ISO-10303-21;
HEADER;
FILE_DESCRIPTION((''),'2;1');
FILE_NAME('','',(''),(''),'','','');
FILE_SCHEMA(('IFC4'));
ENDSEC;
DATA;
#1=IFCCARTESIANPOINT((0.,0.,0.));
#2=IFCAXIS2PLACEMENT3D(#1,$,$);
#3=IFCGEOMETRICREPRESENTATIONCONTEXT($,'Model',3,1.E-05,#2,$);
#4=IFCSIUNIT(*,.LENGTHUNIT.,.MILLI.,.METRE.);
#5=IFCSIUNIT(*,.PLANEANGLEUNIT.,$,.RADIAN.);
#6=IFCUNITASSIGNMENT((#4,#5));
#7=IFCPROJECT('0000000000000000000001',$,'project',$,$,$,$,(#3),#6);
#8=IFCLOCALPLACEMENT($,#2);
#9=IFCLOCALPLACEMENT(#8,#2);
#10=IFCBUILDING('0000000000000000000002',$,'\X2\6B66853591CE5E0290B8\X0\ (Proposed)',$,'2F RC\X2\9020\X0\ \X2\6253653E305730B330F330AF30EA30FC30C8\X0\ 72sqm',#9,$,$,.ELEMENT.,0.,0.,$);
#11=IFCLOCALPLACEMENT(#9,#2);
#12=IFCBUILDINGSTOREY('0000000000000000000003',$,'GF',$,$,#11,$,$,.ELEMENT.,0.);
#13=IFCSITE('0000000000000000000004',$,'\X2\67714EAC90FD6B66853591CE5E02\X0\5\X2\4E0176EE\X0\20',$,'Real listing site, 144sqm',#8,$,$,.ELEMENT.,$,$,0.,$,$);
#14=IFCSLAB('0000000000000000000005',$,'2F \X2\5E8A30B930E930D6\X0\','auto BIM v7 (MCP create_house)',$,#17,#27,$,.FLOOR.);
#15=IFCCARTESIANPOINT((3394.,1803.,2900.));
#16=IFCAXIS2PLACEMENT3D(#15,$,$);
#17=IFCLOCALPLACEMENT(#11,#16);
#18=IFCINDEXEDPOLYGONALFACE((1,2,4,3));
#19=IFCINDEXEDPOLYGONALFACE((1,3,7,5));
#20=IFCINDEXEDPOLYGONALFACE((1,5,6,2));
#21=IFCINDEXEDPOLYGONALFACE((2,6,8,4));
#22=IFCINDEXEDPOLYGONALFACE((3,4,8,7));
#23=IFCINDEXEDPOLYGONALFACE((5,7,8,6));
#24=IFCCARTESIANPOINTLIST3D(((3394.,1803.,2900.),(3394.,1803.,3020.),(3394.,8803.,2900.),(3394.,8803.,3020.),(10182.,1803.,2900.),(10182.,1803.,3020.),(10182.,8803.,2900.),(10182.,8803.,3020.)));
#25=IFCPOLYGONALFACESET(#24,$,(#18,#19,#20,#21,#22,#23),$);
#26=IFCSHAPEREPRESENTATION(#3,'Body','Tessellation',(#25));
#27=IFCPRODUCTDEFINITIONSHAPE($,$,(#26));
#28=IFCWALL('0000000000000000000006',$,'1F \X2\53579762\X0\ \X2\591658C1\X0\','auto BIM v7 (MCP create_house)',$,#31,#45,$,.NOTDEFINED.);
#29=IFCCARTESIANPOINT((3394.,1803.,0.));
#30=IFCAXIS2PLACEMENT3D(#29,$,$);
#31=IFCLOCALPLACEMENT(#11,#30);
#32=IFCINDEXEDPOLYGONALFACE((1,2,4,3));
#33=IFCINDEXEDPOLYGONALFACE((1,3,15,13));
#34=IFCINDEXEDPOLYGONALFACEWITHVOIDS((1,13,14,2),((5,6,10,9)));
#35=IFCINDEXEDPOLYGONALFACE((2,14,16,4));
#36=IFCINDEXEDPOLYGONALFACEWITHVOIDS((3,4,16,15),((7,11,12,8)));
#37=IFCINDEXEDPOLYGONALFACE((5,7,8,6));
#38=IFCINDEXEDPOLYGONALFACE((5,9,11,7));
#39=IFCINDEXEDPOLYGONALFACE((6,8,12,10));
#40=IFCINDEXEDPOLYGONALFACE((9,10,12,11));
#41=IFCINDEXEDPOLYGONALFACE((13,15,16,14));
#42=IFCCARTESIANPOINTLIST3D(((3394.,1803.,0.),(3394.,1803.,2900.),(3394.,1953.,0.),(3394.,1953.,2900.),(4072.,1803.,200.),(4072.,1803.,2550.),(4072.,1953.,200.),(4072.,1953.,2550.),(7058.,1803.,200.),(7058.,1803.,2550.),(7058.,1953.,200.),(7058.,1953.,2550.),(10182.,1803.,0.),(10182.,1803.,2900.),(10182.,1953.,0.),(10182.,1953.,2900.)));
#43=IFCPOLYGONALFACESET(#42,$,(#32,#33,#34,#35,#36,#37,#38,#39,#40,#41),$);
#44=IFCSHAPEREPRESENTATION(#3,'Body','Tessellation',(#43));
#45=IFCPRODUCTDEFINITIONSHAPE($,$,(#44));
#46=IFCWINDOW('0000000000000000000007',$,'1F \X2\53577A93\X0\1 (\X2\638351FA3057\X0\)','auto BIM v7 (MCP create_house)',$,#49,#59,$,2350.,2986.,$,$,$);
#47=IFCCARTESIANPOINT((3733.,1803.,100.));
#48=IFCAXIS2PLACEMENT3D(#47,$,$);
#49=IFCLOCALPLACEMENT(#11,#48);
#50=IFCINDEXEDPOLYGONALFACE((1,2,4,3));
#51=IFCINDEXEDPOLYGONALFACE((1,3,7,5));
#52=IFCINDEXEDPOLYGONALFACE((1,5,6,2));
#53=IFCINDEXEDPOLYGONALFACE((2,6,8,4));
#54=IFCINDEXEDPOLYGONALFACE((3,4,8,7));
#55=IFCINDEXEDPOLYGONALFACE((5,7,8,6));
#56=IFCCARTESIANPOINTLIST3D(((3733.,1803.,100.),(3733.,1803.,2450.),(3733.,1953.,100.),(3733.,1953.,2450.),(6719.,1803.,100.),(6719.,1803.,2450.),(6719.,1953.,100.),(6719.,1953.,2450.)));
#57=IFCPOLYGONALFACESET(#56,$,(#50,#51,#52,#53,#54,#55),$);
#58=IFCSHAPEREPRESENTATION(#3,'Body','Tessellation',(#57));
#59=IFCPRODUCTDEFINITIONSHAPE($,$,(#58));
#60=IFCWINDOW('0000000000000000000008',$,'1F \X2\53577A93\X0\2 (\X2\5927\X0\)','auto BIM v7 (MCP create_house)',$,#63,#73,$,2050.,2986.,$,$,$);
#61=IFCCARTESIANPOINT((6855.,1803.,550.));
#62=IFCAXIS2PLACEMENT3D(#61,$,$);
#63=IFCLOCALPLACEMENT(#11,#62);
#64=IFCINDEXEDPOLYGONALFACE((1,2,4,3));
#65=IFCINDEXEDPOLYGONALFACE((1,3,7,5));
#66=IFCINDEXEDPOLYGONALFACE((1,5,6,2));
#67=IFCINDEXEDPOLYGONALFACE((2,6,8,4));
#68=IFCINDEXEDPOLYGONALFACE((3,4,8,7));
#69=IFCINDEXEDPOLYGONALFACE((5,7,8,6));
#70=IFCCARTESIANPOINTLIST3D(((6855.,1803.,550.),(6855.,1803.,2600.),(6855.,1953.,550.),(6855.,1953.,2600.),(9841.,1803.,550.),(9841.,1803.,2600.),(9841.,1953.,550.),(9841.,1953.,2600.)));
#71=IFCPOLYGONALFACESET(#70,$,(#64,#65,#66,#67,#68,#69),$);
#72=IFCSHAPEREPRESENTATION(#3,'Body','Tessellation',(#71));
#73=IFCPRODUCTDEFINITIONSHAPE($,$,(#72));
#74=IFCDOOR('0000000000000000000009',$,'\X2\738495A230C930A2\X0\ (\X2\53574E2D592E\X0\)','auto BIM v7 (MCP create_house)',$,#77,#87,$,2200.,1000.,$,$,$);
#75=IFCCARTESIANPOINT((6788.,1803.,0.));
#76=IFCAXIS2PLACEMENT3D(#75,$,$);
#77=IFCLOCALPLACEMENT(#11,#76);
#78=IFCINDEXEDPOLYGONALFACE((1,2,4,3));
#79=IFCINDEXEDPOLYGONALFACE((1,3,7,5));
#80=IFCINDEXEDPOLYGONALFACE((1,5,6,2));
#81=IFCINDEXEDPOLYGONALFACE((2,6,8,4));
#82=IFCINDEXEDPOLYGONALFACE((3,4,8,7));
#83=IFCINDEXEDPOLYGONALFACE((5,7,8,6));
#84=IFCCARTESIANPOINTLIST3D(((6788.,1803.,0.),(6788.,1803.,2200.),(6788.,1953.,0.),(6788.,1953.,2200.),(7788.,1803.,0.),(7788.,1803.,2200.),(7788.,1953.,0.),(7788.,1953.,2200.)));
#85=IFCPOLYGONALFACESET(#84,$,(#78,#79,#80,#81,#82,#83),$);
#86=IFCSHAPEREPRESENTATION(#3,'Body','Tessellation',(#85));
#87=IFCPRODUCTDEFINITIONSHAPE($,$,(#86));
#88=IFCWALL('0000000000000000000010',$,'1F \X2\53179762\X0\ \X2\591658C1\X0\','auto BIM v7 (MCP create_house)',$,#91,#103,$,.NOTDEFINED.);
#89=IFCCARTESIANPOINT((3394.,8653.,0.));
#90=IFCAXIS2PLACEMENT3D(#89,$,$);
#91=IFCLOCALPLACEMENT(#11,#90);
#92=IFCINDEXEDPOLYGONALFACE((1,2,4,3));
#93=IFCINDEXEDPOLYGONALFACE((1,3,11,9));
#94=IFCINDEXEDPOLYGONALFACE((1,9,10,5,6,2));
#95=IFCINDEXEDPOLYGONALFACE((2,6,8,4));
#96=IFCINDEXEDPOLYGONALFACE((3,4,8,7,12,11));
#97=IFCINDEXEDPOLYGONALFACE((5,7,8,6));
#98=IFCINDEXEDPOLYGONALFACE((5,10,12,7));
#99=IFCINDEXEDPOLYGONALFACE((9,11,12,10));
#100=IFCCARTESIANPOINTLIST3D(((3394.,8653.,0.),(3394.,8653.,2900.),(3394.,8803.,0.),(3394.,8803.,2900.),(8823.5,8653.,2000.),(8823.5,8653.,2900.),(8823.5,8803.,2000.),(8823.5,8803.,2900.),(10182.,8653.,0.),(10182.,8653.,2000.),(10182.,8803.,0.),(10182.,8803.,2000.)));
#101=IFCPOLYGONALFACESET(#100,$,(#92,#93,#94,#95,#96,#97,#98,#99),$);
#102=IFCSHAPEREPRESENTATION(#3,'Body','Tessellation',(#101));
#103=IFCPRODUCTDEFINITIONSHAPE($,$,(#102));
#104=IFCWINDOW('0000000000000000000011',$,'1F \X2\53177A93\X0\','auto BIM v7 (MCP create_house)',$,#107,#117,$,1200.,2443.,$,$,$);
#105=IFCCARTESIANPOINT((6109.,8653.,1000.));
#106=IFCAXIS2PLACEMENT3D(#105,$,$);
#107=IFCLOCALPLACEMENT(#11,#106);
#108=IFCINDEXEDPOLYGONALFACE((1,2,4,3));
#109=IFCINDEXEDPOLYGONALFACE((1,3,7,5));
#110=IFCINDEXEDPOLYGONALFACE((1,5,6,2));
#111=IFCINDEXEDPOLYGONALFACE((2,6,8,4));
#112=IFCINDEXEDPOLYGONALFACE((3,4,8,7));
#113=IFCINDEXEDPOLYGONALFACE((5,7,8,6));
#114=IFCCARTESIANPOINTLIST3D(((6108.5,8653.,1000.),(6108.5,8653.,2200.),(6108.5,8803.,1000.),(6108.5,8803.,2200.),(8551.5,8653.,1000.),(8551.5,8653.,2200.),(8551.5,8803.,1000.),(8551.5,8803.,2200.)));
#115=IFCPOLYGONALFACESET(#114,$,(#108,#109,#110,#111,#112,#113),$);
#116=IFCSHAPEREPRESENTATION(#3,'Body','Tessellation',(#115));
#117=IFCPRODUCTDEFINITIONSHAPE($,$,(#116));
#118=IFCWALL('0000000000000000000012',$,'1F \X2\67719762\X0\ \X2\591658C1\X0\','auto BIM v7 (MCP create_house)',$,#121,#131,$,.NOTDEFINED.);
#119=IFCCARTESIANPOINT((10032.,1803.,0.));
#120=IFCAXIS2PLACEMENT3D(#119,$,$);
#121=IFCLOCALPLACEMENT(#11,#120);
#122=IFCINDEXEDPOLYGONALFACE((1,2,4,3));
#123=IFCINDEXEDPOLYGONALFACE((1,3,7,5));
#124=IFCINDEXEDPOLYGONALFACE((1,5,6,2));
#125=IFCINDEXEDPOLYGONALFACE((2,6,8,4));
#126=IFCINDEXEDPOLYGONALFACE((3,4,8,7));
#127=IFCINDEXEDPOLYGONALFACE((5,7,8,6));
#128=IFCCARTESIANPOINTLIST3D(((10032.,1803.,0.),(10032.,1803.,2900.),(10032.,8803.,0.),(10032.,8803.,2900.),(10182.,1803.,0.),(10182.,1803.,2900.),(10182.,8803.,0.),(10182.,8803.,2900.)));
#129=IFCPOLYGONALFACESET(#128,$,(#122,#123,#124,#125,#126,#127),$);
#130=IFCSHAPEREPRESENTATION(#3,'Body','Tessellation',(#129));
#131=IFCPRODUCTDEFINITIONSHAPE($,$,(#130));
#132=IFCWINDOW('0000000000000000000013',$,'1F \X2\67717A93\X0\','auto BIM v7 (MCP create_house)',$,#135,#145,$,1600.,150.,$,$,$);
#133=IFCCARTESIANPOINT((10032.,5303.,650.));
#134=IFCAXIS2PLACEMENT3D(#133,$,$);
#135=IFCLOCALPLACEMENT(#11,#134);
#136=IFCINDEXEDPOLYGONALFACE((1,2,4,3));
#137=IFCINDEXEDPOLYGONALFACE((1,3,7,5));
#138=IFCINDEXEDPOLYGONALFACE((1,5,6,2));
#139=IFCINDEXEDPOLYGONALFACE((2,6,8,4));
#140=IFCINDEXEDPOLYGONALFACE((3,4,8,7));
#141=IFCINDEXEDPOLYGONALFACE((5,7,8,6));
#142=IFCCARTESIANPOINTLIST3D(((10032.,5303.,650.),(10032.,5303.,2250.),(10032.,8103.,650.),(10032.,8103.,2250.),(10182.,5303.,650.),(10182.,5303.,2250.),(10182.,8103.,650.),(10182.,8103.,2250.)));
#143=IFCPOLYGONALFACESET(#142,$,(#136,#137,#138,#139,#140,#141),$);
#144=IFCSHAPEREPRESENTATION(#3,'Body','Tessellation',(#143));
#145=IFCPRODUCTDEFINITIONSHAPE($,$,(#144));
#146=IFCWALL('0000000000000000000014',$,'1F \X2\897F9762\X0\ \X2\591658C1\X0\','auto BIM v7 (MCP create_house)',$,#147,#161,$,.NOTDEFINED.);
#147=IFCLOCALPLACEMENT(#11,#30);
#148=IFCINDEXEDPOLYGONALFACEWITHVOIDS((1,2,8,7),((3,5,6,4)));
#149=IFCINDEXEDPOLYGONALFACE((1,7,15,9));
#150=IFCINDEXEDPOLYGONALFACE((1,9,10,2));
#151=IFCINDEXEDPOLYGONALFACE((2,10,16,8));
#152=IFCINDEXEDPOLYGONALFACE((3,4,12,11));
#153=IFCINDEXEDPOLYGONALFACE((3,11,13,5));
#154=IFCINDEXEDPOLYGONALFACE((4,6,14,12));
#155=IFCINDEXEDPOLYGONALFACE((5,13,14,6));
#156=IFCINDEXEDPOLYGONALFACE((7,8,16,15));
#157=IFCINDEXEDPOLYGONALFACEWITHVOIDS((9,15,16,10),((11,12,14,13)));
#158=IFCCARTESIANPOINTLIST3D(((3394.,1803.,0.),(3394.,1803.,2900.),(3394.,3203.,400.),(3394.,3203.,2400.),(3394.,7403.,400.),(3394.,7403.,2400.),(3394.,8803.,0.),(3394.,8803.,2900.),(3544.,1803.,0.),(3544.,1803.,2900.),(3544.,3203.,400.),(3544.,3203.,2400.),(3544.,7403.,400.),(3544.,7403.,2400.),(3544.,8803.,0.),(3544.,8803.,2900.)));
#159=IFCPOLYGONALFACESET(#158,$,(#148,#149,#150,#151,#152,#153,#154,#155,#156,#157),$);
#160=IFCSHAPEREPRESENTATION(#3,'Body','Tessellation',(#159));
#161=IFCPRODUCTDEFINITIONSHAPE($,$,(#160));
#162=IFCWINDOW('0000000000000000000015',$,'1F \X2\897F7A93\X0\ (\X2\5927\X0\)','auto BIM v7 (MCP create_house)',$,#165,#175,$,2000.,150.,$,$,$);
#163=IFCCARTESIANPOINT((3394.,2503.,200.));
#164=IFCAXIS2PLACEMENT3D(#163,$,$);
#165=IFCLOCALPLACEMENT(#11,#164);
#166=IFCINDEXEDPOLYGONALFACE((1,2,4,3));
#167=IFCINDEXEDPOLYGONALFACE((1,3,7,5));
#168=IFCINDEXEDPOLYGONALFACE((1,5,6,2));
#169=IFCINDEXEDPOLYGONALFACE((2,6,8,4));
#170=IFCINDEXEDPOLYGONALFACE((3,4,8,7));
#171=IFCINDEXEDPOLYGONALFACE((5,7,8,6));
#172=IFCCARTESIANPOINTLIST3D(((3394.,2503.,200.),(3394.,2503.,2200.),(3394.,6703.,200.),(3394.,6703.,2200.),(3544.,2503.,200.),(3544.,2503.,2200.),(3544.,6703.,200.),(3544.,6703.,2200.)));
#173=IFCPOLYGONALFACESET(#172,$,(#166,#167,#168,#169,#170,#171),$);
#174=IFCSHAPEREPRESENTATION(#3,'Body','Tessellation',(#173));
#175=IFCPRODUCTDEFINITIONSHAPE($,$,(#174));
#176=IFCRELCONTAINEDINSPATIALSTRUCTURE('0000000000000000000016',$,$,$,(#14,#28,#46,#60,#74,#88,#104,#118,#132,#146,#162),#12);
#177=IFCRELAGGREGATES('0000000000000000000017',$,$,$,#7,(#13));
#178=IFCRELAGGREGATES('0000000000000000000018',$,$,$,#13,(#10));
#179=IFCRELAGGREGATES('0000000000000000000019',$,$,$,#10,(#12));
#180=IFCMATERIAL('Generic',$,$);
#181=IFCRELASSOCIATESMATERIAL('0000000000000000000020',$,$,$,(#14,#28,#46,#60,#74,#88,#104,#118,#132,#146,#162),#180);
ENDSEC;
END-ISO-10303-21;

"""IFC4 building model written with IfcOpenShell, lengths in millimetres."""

from ifc_helpers import new_model, si_unit, frame, frame_2d, origin, place, context, project, spatial, rectangle, extrude, material, element, fill, save


model = new_model("IFC4")

# Units and contexts
model_context = context("Model", 3, precision=1e-05, world=origin())
ifc_project = project(units=[si_unit("LENGTHUNIT", "METRE", prefix="MILLI"), si_unit("PLANEANGLEUNIT", "RADIAN")], contexts=[model_context])

# Site, building, storey
site_placement = place(None, origin())
site = spatial("IfcSite", under=ifc_project, at=site_placement, Name="東京都武蔵野市5丁目20", ObjectType="Real listing site, 144sqm", CompositionType="ELEMENT", RefElevation=0.0)
building_placement = place(site_placement, origin())
building = spatial("IfcBuilding", under=site, at=building_placement, Name="武蔵野市邸 (Proposed)", ObjectType="2F RC造 打放しコンクリート 72sqm", CompositionType="ELEMENT", ElevationOfRefHeight=0.0, ElevationOfTerrain=0.0)
storey_placement = place(building_placement, origin())
storey = spatial("IfcBuildingStorey", under=building, at=storey_placement, Name="GF", CompositionType="ELEMENT", Elevation=0.0)

# Slab
ifc_material = material(Name="Generic")
slab_1_placement = place(storey_placement, frame((3394.0, 1803.0, 2900.0)))
element("IfcSlab", 1, at=slab_1_placement, inside=storey, material=ifc_material, Name="2F 床スラブ", Description="auto BIM v7 (MCP create_house)", PredefinedType="FLOOR", context=model_context, shape_type="SweptSolid", body=[
    extrude(rectangle(XDim=6788.0, YDim=7000.0, at=frame_2d((3394.0, 3500.0))), frame((3394.0, 1803.0, 2900.0)), (0.0, 0.0, 1.0), 120.0),
])

# Wall, openings, windows, door
wall_1_placement = place(storey_placement, frame((3394.0, 1803.0, 0.0)))
wall_1 = element("IfcWall", 2, at=wall_1_placement, inside=storey, material=ifc_material, Name="1F 南面 外壁", Description="auto BIM v7 (MCP create_house)", PredefinedType="NOTDEFINED", context=model_context, shape_type="SweptSolid", body=[
    extrude(rectangle(XDim=6788.0, YDim=150.0, at=frame_2d((3394.0, 75.0))), frame((3394.0, 1803.0, 0.0)), (0.0, 0.0, 1.0), 2900.0),
])
opening_1_placement = place(storey_placement, frame((3733.0, 1803.0, 100.0)))
opening_1 = element("IfcOpeningElement", 3, at=opening_1_placement, cuts=wall_1, PredefinedType="NOTDEFINED", context=model_context, shape_type="SweptSolid", body=[
    extrude(rectangle(XDim=2986.0, YDim=150.0, at=frame_2d((1493.0, 75.0))), frame((3733.0, 1803.0, 100.0)), (0.0, 0.0, 1.0), 2350.0),
])
opening_2_placement = place(storey_placement, frame((6855.0, 1803.0, 550.0)))
opening_2 = element("IfcOpeningElement", 4, at=opening_2_placement, cuts=wall_1, PredefinedType="NOTDEFINED", context=model_context, shape_type="SweptSolid", body=[
    extrude(rectangle(XDim=2986.0, YDim=150.0, at=frame_2d((1493.0, 75.0))), frame((6855.0, 1803.0, 550.0)), (0.0, 0.0, 1.0), 2050.0),
])
opening_3_placement = place(storey_placement, frame((6788.0, 1803.0, 0.0)))
opening_3 = element("IfcOpeningElement", 5, at=opening_3_placement, cuts=wall_1, PredefinedType="NOTDEFINED", context=model_context, shape_type="SweptSolid", body=[
    extrude(rectangle(XDim=1000.0, YDim=150.0, at=frame_2d((500.0, 75.0))), frame((6788.0, 1803.0, 0.0)), (0.0, 0.0, 1.0), 2200.0),
])
window_1_placement = place(storey_placement, frame((3733.0, 1803.0, 100.0)))
window_1 = element("IfcWindow", 6, at=window_1_placement, inside=storey, material=ifc_material, Name="1F 南窓1 (掃出し)", Description="auto BIM v7 (MCP create_house)", OverallHeight=2350.0, OverallWidth=2986.0, context=model_context, shape_type="SweptSolid", body=[
    extrude(rectangle(XDim=2986.0, YDim=150.0, at=frame_2d((1493.0, 75.0))), frame((3733.0, 1803.0, 100.0)), (0.0, 0.0, 1.0), 2350.0),
])
fill(opening_1, window_1)
window_2_placement = place(storey_placement, frame((6855.0, 1803.0, 550.0)))
window_2 = element("IfcWindow", 7, at=window_2_placement, inside=storey, material=ifc_material, Name="1F 南窓2 (大)", Description="auto BIM v7 (MCP create_house)", OverallHeight=2050.0, OverallWidth=2986.0, context=model_context, shape_type="SweptSolid", body=[
    extrude(rectangle(XDim=2986.0, YDim=150.0, at=frame_2d((1493.0, 75.0))), frame((6855.0, 1803.0, 550.0)), (0.0, 0.0, 1.0), 2050.0),
])
fill(opening_2, window_2)
door_placement = place(storey_placement, frame((6788.0, 1803.0, 0.0)))
door = element("IfcDoor", 8, at=door_placement, inside=storey, material=ifc_material, Name="玄関ドア (南中央)", Description="auto BIM v7 (MCP create_house)", OverallHeight=2200.0, OverallWidth=1000.0, context=model_context, shape_type="SweptSolid", body=[
    extrude(rectangle(XDim=1000.0, YDim=150.0, at=frame_2d((500.0, 75.0))), frame((6788.0, 1803.0, 0.0)), (0.0, 0.0, 1.0), 2200.0),
])
fill(opening_3, door)

# Walls, openings, windows
wall_2_placement = place(storey_placement, frame((3394.0, 8653.0, 0.0)))
wall_2 = element("IfcWall", 9, at=wall_2_placement, inside=storey, material=ifc_material, Name="1F 北面 外壁", Description="auto BIM v7 (MCP create_house)", PredefinedType="NOTDEFINED", context=model_context, shape_type="SweptSolid", body=[
    extrude(rectangle(XDim=6788.0, YDim=150.0, at=frame_2d((3394.0, 75.0))), frame((3394.0, 8653.0, 0.0)), (0.0, 0.0, 1.0), 2900.0),
])
opening_4_placement = place(storey_placement, frame((6109.0, 8653.0, 1000.0)))
opening_4 = element("IfcOpeningElement", 10, at=opening_4_placement, cuts=wall_2, PredefinedType="NOTDEFINED", context=model_context, shape_type="SweptSolid", body=[
    extrude(rectangle(XDim=2443.0, YDim=150.0, at=frame_2d((1221.0, 75.0))), frame((6109.0, 8653.0, 1000.0)), (0.0, 0.0, 1.0), 1200.0),
])
window_3_placement = place(storey_placement, frame((6109.0, 8653.0, 1000.0)))
window_3 = element("IfcWindow", 11, at=window_3_placement, inside=storey, material=ifc_material, Name="1F 北窓", Description="auto BIM v7 (MCP create_house)", OverallHeight=1200.0, OverallWidth=2443.0, context=model_context, shape_type="SweptSolid", body=[
    extrude(rectangle(XDim=2443.0, YDim=150.0, at=frame_2d((1221.0, 75.0))), frame((6109.0, 8653.0, 1000.0)), (0.0, 0.0, 1.0), 1200.0),
])
fill(opening_4, window_3)
wall_3_placement = place(storey_placement, frame((10032.0, 1803.0, 0.0)))
wall_3 = element("IfcWall", 12, at=wall_3_placement, inside=storey, material=ifc_material, Name="1F 東面 外壁", Description="auto BIM v7 (MCP create_house)", PredefinedType="NOTDEFINED", context=model_context, shape_type="SweptSolid", body=[
    extrude(rectangle(XDim=150.0, YDim=7000.0, at=frame_2d((75.0, 3500.0))), frame((10032.0, 1803.0, 0.0)), (0.0, 0.0, 1.0), 2900.0),
])
opening_5_placement = place(storey_placement, frame((10032.0, 5303.0, 650.0)))
opening_5 = element("IfcOpeningElement", 13, at=opening_5_placement, cuts=wall_3, PredefinedType="NOTDEFINED", context=model_context, shape_type="SweptSolid", body=[
    extrude(rectangle(XDim=150.0, YDim=2800.0, at=frame_2d((75.0, 1400.0))), frame((10032.0, 5303.0, 650.0)), (0.0, 0.0, 1.0), 1600.0),
])
window_4_placement = place(storey_placement, frame((10032.0, 5303.0, 650.0)))
window_4 = element("IfcWindow", 14, at=window_4_placement, inside=storey, material=ifc_material, Name="1F 東窓", Description="auto BIM v7 (MCP create_house)", OverallHeight=1600.0, OverallWidth=150.0, context=model_context, shape_type="SweptSolid", body=[
    extrude(rectangle(XDim=150.0, YDim=2800.0, at=frame_2d((75.0, 1400.0))), frame((10032.0, 5303.0, 650.0)), (0.0, 0.0, 1.0), 1600.0),
])
fill(opening_5, window_4)
wall_4_placement = place(storey_placement, frame((3394.0, 1803.0, 0.0)))
wall_4 = element("IfcWall", 15, at=wall_4_placement, inside=storey, material=ifc_material, Name="1F 西面 外壁", Description="auto BIM v7 (MCP create_house)", PredefinedType="NOTDEFINED", context=model_context, shape_type="SweptSolid", body=[
    extrude(rectangle(XDim=150.0, YDim=7000.0, at=frame_2d((75.0, 3500.0))), frame((3394.0, 1803.0, 0.0)), (0.0, 0.0, 1.0), 2900.0),
])
opening_6_placement = place(storey_placement, frame((3394.0, 2503.0, 200.0)))
opening_6 = element("IfcOpeningElement", 16, at=opening_6_placement, cuts=wall_4, PredefinedType="NOTDEFINED", context=model_context, shape_type="SweptSolid", body=[
    extrude(rectangle(XDim=150.0, YDim=4200.0, at=frame_2d((75.0, 2100.0))), frame((3394.0, 2503.0, 200.0)), (0.0, 0.0, 1.0), 2000.0),
])
window_5_placement = place(storey_placement, frame((3394.0, 2503.0, 200.0)))
window_5 = element("IfcWindow", 17, at=window_5_placement, inside=storey, material=ifc_material, Name="1F 西窓 (大)", Description="auto BIM v7 (MCP create_house)", OverallHeight=2000.0, OverallWidth=150.0, context=model_context, shape_type="SweptSolid", body=[
    extrude(rectangle(XDim=150.0, YDim=4200.0, at=frame_2d((75.0, 2100.0))), frame((3394.0, 2503.0, 200.0)), (0.0, 0.0, 1.0), 2000.0),
])
fill(opening_6, window_5)

save(model, "model.ifc")
